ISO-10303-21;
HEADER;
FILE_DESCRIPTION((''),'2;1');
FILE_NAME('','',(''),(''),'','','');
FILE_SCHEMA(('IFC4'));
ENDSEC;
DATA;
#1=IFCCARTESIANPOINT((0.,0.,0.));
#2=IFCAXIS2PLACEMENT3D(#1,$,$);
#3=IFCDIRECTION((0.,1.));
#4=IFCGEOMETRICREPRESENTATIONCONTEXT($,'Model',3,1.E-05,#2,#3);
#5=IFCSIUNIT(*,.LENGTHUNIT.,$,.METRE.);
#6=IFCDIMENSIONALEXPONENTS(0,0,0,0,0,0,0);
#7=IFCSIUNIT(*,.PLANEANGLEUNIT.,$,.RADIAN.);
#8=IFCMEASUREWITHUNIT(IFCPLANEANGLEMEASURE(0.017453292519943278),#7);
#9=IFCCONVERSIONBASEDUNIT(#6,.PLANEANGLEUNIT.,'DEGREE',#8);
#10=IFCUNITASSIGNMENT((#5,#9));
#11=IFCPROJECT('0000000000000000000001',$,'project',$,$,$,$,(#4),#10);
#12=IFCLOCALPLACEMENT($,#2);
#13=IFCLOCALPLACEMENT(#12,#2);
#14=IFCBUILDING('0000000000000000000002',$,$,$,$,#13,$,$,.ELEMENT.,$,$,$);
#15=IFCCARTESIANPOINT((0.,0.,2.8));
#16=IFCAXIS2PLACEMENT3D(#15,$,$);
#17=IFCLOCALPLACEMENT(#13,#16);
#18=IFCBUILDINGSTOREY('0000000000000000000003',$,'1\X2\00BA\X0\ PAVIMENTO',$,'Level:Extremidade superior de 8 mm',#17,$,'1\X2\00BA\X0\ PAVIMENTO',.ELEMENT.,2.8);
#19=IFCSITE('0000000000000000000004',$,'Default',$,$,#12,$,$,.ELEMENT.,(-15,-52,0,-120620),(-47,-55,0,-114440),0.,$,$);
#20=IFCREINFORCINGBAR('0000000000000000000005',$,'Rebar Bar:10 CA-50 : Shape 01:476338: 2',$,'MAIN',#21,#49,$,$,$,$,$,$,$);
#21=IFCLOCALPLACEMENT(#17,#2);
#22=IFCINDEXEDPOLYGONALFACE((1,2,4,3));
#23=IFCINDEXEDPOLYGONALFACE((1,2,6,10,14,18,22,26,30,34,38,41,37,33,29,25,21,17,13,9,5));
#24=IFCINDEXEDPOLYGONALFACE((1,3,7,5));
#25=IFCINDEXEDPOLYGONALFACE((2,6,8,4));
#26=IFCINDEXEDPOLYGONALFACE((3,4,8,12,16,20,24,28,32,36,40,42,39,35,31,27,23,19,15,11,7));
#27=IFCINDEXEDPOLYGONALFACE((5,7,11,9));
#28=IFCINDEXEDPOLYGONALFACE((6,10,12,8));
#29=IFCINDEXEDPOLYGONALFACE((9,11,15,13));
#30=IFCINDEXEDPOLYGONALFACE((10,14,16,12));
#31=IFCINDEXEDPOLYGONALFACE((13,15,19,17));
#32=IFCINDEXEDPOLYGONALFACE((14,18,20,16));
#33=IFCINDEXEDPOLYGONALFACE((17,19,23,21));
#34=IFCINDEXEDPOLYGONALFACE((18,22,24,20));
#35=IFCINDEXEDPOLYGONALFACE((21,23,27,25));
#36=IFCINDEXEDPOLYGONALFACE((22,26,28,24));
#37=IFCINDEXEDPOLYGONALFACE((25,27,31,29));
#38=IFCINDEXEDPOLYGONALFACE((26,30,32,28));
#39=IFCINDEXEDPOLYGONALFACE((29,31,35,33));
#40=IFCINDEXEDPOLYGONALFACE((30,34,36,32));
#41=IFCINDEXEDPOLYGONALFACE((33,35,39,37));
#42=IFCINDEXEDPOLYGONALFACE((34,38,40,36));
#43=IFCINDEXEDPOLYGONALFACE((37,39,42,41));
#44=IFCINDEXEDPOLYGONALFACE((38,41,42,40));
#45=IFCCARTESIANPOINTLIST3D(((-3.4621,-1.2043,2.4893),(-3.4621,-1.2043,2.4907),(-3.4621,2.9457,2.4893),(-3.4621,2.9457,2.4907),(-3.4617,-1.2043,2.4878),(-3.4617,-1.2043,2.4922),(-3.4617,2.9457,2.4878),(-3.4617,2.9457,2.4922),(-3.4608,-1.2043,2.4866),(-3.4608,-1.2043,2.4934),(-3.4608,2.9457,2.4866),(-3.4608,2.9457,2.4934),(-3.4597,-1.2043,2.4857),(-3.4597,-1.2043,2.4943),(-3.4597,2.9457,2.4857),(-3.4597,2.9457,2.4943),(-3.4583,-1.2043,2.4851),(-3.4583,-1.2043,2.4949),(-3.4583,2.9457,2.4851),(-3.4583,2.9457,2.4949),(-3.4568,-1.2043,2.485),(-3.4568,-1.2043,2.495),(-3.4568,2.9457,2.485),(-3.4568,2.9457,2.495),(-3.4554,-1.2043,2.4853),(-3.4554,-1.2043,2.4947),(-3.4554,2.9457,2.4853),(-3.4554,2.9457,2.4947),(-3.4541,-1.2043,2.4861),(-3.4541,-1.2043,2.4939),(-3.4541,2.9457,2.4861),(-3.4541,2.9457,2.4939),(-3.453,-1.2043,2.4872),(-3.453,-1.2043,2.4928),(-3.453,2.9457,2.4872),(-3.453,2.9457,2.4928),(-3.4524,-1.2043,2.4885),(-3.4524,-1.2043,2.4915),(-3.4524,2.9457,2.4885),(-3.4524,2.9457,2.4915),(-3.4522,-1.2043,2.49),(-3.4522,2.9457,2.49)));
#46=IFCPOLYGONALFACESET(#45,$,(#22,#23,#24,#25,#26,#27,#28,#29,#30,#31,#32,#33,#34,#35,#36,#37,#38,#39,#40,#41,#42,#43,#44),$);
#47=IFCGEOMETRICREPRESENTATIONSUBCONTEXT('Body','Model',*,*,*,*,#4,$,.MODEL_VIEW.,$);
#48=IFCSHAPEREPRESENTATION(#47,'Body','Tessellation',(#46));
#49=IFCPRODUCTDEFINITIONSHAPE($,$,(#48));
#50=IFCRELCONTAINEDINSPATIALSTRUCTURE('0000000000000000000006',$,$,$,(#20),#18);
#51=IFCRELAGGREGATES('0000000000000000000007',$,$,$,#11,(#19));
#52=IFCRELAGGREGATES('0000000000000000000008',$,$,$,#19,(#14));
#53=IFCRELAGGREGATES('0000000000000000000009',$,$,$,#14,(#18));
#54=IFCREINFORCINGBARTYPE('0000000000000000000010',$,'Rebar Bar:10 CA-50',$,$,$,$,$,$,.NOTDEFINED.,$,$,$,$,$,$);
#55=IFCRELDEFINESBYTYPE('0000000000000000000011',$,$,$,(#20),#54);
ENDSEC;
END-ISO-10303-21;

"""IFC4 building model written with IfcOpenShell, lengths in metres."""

from ifc_helpers import new_model, entity, si_unit, converted_unit, direction, frame, origin, place, context, subcontext, project, spatial, type_object, element, save


model = new_model("IFC4")

# Units and contexts
model_context = context("Model", 3, precision=1e-05, world=origin(), true_north=direction((0.0, 1.0)))
body_context = subcontext(model_context, "Body", "Model", "MODEL_VIEW")
ifc_project = project(units=[si_unit("LENGTHUNIT", "METRE"), converted_unit("PLANEANGLEUNIT", "DEGREE", entity("IfcPlaneAngleMeasure", 0.017453292519943278), si_unit("PLANEANGLEUNIT", "RADIAN"), dimensions=[0, 0, 0, 0, 0, 0, 0])], contexts=[model_context])

# Site, building, storey
site_placement = place(None, origin())
site = spatial("IfcSite", under=ifc_project, at=site_placement, Name="Default", CompositionType="ELEMENT", RefLatitude=(-15, -52, 0, -120620), RefLongitude=(-47, -55, 0, -114440), RefElevation=0.0)
building_placement = place(site_placement, origin())
building = spatial("IfcBuilding", under=site, at=building_placement, CompositionType="ELEMENT")
storey_placement = place(building_placement, frame((0.0, 0.0, 2.8)))
storey = spatial("IfcBuildingStorey", under=building, at=storey_placement, Name="1º PAVIMENTO", ObjectType="Level:Extremidade superior de 8 mm", LongName="1º PAVIMENTO", CompositionType="ELEMENT", Elevation=2.8)

# Reinforcing bar
reinforcing_bar_type_1 = type_object("IfcReinforcingBarType", Name="Rebar Bar:10 CA-50", PredefinedType="NOTDEFINED")
reinforcing_bar_1_placement = place(storey_placement, origin())
element("IfcReinforcingBar", 1, at=reinforcing_bar_1_placement, inside=storey, type_object=reinforcing_bar_type_1, Name="Rebar Bar:10 CA-50 : Shape 01:476338: 2", ObjectType="MAIN", context=body_context, shape_type="AdvancedSweptSolid", body=[
    entity("IfcSweptDiskSolid", entity("IfcIndexedPolyCurve", entity("IfcCartesianPointList3D", [[-3.4572, -1.2043, 2.49], [-3.4572, 2.9457, 2.49]]), None, False), 0.005, None, 0.0, 1.0),
])

save(model, "model.ifc")
